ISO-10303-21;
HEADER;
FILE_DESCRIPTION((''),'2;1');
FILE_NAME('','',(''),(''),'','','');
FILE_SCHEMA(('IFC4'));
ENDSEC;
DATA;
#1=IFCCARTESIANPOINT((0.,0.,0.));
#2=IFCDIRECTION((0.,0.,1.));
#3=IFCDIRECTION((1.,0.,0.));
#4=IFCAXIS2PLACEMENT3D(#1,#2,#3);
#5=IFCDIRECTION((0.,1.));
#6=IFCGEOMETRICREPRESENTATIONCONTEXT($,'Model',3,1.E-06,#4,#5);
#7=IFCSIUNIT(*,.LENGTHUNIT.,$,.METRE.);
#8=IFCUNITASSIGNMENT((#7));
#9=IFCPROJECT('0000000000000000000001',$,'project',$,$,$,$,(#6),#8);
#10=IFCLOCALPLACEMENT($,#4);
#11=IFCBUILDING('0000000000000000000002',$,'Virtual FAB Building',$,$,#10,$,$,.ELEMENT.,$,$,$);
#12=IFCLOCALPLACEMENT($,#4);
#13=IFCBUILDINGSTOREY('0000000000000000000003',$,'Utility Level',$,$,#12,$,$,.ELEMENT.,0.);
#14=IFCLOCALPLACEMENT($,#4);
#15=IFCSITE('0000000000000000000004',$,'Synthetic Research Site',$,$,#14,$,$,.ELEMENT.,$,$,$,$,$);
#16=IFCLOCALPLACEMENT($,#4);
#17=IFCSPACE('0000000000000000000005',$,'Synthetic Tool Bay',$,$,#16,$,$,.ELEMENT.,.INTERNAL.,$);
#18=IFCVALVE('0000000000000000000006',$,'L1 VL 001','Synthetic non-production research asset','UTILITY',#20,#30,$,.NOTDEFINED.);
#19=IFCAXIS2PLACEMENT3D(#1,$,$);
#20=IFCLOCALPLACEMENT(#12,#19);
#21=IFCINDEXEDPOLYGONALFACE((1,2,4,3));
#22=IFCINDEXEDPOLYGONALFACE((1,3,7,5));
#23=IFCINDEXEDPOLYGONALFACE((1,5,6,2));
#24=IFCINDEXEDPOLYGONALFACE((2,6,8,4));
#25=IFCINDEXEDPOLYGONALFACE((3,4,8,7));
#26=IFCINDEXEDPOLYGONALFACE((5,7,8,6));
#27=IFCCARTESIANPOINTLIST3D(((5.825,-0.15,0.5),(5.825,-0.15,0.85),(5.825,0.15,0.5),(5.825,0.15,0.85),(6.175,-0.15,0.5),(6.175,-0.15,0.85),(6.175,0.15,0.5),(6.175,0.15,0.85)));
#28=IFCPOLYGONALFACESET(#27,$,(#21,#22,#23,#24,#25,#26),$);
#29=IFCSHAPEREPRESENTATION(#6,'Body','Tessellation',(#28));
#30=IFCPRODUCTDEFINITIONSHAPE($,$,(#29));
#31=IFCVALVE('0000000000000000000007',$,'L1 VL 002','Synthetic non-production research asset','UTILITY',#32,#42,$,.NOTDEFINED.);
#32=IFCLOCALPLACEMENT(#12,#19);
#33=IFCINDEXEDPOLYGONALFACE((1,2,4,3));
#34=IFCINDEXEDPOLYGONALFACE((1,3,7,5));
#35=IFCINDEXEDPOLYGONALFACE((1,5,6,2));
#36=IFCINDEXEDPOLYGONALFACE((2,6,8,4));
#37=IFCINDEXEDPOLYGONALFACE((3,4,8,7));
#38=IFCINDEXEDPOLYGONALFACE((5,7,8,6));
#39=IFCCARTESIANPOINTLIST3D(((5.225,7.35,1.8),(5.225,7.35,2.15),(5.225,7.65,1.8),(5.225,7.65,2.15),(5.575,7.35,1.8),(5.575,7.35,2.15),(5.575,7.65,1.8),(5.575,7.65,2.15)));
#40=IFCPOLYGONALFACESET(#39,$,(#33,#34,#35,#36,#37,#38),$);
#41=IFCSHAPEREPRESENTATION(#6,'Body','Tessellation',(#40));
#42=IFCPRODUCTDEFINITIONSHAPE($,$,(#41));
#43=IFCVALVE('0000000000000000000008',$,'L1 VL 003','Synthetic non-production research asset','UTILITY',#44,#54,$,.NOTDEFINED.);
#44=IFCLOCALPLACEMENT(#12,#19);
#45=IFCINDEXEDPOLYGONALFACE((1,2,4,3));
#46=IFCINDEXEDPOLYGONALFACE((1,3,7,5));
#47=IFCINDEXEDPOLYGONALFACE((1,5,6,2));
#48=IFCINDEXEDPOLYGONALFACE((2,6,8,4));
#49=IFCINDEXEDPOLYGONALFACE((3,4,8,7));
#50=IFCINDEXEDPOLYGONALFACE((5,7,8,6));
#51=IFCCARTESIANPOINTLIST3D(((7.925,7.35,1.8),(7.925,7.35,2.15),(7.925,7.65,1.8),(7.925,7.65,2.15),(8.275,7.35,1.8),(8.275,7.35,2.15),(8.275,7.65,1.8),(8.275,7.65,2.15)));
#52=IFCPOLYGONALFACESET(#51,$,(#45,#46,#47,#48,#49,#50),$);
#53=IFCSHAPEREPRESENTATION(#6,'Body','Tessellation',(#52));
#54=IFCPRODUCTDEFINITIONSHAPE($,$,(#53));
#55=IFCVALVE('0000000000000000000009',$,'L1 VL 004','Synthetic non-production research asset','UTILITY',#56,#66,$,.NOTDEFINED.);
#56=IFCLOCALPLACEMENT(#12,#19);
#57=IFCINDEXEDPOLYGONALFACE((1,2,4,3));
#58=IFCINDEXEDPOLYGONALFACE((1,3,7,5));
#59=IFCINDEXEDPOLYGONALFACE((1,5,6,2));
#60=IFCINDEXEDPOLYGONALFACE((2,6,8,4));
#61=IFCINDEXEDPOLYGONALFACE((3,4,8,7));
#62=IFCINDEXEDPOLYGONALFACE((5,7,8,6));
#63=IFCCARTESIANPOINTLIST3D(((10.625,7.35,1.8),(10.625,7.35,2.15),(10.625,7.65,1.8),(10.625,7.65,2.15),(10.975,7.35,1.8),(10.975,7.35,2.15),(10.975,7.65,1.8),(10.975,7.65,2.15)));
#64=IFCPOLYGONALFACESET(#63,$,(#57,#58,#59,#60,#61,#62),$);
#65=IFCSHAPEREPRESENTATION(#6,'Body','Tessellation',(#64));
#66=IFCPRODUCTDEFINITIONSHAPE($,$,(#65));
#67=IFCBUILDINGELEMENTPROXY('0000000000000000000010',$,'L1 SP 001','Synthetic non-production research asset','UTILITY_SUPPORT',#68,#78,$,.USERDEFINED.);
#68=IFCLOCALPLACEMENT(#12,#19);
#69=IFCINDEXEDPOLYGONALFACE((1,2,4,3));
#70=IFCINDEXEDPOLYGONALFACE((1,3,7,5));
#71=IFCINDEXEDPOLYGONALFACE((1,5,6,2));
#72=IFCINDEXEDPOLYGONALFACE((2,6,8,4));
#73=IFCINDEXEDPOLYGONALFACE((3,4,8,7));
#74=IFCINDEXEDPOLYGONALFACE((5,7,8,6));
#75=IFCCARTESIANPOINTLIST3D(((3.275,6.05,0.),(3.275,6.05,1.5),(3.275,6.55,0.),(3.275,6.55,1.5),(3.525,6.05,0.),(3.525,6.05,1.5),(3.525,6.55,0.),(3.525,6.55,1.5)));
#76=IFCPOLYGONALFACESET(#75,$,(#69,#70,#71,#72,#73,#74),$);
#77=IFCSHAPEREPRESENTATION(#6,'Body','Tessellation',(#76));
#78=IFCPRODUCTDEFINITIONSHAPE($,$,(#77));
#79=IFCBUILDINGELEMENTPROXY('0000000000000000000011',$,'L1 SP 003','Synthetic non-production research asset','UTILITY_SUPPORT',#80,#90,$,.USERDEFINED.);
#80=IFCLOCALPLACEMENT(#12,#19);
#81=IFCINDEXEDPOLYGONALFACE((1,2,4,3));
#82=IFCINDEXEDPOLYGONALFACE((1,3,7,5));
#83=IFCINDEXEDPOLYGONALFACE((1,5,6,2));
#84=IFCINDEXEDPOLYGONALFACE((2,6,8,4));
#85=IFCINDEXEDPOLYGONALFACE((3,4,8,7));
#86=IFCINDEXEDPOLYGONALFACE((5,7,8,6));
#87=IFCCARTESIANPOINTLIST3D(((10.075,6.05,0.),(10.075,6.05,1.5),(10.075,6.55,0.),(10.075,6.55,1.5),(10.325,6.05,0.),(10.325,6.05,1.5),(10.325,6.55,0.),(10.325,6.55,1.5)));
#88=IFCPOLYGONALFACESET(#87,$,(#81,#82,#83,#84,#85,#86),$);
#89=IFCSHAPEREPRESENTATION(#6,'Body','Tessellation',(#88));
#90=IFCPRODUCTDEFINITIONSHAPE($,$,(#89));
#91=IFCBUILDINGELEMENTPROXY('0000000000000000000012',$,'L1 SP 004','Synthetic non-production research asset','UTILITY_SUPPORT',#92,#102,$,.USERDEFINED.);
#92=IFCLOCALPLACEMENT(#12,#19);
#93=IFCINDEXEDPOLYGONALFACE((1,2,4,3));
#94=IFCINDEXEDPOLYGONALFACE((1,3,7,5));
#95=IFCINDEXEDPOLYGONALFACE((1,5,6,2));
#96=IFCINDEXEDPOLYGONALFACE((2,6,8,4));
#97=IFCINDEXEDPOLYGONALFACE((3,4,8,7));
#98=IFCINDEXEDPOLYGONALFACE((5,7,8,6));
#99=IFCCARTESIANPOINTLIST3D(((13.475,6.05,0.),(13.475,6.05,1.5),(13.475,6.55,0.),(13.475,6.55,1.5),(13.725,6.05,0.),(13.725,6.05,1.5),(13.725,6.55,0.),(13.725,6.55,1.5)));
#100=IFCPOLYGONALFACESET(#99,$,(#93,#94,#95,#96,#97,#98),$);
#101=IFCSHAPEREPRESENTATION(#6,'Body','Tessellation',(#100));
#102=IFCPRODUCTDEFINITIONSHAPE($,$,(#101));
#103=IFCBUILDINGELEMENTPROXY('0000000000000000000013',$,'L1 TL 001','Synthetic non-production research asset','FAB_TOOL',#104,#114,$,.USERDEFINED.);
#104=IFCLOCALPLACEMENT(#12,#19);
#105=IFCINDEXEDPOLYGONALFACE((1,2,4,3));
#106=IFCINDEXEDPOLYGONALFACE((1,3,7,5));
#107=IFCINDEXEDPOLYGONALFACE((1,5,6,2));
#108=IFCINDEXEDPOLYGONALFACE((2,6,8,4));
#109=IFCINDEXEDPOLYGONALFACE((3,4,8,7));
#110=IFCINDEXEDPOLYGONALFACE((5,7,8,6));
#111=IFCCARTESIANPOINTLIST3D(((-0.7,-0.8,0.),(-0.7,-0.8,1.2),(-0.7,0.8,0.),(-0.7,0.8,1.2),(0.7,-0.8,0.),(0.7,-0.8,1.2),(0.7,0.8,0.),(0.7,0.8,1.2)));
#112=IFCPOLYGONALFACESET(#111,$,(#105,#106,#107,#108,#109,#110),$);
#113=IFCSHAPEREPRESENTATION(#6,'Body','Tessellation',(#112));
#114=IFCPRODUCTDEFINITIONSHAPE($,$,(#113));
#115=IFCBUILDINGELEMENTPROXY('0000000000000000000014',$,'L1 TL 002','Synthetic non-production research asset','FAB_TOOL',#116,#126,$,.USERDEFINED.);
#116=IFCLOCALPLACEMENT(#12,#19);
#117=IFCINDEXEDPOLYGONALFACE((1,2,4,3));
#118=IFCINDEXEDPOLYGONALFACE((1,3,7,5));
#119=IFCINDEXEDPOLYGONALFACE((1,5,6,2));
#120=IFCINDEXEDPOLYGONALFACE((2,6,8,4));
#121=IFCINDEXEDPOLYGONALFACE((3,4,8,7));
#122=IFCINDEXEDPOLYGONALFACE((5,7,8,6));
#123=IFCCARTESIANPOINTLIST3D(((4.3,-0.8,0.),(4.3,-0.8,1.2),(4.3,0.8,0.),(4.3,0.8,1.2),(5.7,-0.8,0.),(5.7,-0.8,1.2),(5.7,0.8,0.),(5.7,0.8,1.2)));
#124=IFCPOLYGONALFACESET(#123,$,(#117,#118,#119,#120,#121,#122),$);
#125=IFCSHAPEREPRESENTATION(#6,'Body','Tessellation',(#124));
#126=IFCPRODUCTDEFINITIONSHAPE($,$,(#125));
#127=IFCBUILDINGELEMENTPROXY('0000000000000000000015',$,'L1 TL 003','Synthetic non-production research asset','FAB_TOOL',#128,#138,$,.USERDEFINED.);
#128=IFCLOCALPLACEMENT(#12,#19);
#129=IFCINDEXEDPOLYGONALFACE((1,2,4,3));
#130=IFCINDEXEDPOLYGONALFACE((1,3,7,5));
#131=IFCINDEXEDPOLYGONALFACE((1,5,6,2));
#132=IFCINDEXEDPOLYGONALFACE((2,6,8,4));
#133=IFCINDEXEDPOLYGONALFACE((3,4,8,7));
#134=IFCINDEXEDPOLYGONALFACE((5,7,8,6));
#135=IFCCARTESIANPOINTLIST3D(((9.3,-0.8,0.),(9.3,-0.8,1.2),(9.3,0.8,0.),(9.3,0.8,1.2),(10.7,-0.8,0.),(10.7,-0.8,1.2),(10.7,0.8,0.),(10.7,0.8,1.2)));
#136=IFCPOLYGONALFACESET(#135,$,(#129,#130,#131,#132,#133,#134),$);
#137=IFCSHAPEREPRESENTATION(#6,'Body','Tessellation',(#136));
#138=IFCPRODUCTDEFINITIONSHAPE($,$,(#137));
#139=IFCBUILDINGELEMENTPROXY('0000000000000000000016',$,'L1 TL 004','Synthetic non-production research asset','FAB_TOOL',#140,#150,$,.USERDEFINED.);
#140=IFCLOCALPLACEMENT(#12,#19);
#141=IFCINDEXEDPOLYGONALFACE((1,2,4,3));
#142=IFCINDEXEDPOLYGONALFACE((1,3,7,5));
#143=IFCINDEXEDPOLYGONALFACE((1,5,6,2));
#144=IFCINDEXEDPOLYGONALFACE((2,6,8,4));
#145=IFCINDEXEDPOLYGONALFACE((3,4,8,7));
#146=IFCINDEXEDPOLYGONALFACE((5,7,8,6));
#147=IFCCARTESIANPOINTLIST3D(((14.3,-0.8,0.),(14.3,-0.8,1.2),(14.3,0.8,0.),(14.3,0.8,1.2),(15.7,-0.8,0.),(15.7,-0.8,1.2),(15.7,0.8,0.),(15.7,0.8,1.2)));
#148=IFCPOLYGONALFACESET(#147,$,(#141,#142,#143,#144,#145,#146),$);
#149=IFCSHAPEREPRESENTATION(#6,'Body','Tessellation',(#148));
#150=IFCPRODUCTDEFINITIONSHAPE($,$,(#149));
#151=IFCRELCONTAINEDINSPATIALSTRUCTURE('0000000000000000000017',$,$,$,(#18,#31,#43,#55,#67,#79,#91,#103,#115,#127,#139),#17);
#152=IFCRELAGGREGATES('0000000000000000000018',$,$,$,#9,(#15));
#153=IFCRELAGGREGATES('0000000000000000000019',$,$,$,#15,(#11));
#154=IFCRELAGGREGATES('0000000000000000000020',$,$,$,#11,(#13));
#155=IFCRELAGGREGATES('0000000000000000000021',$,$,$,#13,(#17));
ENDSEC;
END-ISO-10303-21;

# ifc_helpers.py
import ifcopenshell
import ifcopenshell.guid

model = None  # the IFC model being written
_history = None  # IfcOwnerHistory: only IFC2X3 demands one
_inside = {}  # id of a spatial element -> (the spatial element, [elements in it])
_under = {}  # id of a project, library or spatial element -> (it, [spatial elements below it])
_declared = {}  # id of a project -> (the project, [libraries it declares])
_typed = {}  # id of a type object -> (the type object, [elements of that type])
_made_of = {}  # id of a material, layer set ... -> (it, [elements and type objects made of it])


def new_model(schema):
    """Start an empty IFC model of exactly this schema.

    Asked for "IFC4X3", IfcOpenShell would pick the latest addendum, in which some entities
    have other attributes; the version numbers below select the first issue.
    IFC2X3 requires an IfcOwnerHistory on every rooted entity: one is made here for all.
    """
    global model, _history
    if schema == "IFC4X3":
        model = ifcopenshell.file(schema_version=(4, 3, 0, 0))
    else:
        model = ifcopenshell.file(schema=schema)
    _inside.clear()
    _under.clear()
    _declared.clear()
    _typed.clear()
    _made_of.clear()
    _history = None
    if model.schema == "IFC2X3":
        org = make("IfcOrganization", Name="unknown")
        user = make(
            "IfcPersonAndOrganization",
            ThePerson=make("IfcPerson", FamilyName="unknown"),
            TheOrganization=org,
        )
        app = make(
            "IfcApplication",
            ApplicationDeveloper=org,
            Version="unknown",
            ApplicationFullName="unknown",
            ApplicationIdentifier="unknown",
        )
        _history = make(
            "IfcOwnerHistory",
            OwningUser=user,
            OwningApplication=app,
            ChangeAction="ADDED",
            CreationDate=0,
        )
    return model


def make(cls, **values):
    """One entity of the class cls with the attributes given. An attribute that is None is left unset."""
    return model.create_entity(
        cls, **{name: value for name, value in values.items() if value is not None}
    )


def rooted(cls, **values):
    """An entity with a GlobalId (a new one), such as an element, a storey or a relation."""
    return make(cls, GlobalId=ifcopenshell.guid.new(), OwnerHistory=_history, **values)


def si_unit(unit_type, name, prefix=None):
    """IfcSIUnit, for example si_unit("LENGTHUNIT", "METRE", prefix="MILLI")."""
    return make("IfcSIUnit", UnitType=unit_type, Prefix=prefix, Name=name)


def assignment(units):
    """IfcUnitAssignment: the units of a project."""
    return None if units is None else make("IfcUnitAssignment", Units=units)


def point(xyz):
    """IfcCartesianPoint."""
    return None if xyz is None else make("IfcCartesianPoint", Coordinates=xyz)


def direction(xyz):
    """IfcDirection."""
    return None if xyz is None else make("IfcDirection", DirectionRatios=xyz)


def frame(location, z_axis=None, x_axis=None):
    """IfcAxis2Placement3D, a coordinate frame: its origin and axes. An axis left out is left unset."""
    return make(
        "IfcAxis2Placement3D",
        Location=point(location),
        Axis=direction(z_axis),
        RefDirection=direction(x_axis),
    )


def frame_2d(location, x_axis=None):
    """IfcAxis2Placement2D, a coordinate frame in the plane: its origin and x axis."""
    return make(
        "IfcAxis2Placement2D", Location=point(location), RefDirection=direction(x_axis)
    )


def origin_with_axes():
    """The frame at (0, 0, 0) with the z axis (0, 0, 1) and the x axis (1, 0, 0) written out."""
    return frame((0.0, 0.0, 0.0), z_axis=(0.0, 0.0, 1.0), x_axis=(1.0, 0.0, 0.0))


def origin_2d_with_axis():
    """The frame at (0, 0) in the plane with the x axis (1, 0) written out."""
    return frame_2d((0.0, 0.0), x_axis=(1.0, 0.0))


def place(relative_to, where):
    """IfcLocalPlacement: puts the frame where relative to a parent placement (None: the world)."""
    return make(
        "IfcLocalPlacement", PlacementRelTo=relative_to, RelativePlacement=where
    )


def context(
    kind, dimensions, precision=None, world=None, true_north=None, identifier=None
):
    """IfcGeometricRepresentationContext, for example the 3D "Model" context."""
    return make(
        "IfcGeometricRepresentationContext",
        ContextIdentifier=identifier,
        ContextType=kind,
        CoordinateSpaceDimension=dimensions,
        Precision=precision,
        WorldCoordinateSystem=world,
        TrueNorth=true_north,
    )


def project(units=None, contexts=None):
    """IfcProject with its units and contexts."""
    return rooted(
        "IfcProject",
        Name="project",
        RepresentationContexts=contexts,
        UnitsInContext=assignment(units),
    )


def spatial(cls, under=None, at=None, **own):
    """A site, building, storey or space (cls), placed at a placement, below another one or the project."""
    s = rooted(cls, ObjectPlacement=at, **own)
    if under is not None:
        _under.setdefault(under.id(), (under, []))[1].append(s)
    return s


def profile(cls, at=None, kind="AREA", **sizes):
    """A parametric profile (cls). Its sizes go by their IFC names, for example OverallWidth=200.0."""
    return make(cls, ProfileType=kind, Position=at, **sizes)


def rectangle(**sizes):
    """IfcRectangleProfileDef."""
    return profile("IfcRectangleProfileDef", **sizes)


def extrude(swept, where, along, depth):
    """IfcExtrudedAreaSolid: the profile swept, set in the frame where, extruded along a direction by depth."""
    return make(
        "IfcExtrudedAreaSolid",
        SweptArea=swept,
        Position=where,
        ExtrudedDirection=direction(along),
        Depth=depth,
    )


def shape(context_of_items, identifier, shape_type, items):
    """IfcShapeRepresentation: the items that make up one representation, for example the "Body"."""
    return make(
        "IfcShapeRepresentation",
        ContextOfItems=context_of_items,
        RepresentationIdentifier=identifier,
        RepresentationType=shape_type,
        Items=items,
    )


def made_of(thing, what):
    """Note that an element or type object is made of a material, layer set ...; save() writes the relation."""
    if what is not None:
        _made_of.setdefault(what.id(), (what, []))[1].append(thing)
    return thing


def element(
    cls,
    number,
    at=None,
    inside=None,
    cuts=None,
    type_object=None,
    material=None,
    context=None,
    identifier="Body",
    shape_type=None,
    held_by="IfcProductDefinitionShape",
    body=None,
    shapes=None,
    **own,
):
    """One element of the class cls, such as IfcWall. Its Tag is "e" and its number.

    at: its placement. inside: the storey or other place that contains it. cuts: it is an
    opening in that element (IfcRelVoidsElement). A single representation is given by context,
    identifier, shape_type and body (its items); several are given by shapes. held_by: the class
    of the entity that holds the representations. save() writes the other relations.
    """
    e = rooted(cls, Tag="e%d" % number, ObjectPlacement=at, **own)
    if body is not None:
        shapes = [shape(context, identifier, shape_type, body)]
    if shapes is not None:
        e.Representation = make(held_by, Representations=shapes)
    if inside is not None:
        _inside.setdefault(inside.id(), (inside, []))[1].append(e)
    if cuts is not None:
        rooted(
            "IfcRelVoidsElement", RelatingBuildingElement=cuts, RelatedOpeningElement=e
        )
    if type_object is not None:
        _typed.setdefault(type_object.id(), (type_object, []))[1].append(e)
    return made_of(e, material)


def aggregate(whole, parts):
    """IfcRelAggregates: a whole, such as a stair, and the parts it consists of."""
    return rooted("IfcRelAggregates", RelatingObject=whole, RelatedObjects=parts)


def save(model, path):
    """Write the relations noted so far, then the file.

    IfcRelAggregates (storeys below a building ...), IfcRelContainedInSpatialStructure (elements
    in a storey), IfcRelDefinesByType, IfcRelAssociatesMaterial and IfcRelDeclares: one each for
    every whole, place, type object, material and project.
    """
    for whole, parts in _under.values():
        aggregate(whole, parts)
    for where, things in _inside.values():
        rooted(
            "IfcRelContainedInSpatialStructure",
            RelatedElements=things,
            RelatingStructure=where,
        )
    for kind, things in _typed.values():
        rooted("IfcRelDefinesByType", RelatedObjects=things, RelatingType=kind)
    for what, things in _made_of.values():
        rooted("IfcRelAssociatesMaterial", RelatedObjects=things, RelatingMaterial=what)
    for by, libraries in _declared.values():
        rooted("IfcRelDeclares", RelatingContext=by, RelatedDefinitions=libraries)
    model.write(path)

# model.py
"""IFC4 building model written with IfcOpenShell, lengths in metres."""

from ifc_helpers import new_model, si_unit, direction, frame, origin_with_axes, origin_2d_with_axis, place, context, project, spatial, rectangle, extrude, element, save


model = new_model("IFC4")

# Units and contexts
model_context = context("Model", 3, precision=1e-06, world=origin_with_axes(), true_north=direction((0.0, 1.0)))
ifc_project = project(units=[si_unit("LENGTHUNIT", "METRE")], contexts=[model_context])

# Site, building, storey, space
site_placement = place(None, origin_with_axes())
site = spatial("IfcSite", under=ifc_project, at=site_placement, Name="Synthetic Research Site", CompositionType="ELEMENT")
building_placement = place(None, origin_with_axes())
building = spatial("IfcBuilding", under=site, at=building_placement, Name="Virtual FAB Building", CompositionType="ELEMENT")
storey_placement = place(None, origin_with_axes())
storey = spatial("IfcBuildingStorey", under=building, at=storey_placement, Name="Utility Level", CompositionType="ELEMENT", Elevation=0.0)
space_placement = place(None, origin_with_axes())
space = spatial("IfcSpace", under=storey, at=space_placement, Name="Synthetic Tool Bay", CompositionType="ELEMENT", PredefinedType="INTERNAL")

# Valves
for number, where, z_axis, x_axis, name in (
    (1, (6.0, 0.0, 0.5), (0.0, 0.0, 1.0), (1.0, 0.0, 0.0), "L1 VL 001"),
    (2, (5.4, 7.5, 1.8), (0.0, 0.0, 1.0), (1.0, 0.0, 0.0), "L1 VL 002"),
    (3, (8.1, 7.5, 1.8), (0.0, 0.0, 1.0), (1.0, 0.0, 0.0), "L1 VL 003"),
    (4, (10.8, 7.5, 1.8), (0.0, 0.0, 1.0), (1.0, 0.0, 0.0), "L1 VL 004"),
):
    element("IfcValve", number, at=place(None, frame(where, z_axis=z_axis, x_axis=x_axis)), inside=space, Name=name, Description="Synthetic non-production research asset", ObjectType="UTILITY", PredefinedType="NOTDEFINED", context=model_context, shape_type="SweptSolid", body=[
        extrude(rectangle(XDim=0.35, YDim=0.3, at=origin_2d_with_axis()), origin_with_axes(), (0.0, 0.0, 1.0), 0.35),
    ])

# Building element proxies
for number, where, z_axis, x_axis, name in (
    (5, (3.4, 6.3, 0.0), (0.0, 0.0, 1.0), (1.0, 0.0, 0.0), "L1 SP 001"),
    (6, (10.2, 6.3, 0.0), (0.0, 0.0, 1.0), (1.0, 0.0, 0.0), "L1 SP 003"),
    (7, (13.6, 6.3, 0.0), (0.0, 0.0, 1.0), (1.0, 0.0, 0.0), "L1 SP 004"),
):
    element("IfcBuildingElementProxy", number, at=place(None, frame(where, z_axis=z_axis, x_axis=x_axis)), inside=space, Name=name, Description="Synthetic non-production research asset", ObjectType="UTILITY_SUPPORT", PredefinedType="USERDEFINED", context=model_context, shape_type="SweptSolid", body=[
        extrude(rectangle(XDim=0.25, YDim=0.5, at=origin_2d_with_axis()), origin_with_axes(), (0.0, 0.0, 1.0), 1.5),
    ])
for number, where, z_axis, x_axis, name in (
    (8, (0.0, 0.0, 0.0), (0.0, 0.0, 1.0), (1.0, 0.0, 0.0), "L1 TL 001"),
    (9, (5.0, 0.0, 0.0), (0.0, 0.0, 1.0), (1.0, 0.0, 0.0), "L1 TL 002"),
    (10, (10.0, 0.0, 0.0), (0.0, 0.0, 1.0), (1.0, 0.0, 0.0), "L1 TL 003"),
    (11, (15.0, 0.0, 0.0), (0.0, 0.0, 1.0), (1.0, 0.0, 0.0), "L1 TL 004"),
):
    element("IfcBuildingElementProxy", number, at=place(None, frame(where, z_axis=z_axis, x_axis=x_axis)), inside=space, Name=name, Description="Synthetic non-production research asset", ObjectType="FAB_TOOL", PredefinedType="USERDEFINED", context=model_context, shape_type="SweptSolid", body=[
        extrude(rectangle(XDim=1.4, YDim=1.6, at=origin_2d_with_axis()), origin_with_axes(), (0.0, 0.0, 1.0), 1.2),
    ])

save(model, "model.ifc")
